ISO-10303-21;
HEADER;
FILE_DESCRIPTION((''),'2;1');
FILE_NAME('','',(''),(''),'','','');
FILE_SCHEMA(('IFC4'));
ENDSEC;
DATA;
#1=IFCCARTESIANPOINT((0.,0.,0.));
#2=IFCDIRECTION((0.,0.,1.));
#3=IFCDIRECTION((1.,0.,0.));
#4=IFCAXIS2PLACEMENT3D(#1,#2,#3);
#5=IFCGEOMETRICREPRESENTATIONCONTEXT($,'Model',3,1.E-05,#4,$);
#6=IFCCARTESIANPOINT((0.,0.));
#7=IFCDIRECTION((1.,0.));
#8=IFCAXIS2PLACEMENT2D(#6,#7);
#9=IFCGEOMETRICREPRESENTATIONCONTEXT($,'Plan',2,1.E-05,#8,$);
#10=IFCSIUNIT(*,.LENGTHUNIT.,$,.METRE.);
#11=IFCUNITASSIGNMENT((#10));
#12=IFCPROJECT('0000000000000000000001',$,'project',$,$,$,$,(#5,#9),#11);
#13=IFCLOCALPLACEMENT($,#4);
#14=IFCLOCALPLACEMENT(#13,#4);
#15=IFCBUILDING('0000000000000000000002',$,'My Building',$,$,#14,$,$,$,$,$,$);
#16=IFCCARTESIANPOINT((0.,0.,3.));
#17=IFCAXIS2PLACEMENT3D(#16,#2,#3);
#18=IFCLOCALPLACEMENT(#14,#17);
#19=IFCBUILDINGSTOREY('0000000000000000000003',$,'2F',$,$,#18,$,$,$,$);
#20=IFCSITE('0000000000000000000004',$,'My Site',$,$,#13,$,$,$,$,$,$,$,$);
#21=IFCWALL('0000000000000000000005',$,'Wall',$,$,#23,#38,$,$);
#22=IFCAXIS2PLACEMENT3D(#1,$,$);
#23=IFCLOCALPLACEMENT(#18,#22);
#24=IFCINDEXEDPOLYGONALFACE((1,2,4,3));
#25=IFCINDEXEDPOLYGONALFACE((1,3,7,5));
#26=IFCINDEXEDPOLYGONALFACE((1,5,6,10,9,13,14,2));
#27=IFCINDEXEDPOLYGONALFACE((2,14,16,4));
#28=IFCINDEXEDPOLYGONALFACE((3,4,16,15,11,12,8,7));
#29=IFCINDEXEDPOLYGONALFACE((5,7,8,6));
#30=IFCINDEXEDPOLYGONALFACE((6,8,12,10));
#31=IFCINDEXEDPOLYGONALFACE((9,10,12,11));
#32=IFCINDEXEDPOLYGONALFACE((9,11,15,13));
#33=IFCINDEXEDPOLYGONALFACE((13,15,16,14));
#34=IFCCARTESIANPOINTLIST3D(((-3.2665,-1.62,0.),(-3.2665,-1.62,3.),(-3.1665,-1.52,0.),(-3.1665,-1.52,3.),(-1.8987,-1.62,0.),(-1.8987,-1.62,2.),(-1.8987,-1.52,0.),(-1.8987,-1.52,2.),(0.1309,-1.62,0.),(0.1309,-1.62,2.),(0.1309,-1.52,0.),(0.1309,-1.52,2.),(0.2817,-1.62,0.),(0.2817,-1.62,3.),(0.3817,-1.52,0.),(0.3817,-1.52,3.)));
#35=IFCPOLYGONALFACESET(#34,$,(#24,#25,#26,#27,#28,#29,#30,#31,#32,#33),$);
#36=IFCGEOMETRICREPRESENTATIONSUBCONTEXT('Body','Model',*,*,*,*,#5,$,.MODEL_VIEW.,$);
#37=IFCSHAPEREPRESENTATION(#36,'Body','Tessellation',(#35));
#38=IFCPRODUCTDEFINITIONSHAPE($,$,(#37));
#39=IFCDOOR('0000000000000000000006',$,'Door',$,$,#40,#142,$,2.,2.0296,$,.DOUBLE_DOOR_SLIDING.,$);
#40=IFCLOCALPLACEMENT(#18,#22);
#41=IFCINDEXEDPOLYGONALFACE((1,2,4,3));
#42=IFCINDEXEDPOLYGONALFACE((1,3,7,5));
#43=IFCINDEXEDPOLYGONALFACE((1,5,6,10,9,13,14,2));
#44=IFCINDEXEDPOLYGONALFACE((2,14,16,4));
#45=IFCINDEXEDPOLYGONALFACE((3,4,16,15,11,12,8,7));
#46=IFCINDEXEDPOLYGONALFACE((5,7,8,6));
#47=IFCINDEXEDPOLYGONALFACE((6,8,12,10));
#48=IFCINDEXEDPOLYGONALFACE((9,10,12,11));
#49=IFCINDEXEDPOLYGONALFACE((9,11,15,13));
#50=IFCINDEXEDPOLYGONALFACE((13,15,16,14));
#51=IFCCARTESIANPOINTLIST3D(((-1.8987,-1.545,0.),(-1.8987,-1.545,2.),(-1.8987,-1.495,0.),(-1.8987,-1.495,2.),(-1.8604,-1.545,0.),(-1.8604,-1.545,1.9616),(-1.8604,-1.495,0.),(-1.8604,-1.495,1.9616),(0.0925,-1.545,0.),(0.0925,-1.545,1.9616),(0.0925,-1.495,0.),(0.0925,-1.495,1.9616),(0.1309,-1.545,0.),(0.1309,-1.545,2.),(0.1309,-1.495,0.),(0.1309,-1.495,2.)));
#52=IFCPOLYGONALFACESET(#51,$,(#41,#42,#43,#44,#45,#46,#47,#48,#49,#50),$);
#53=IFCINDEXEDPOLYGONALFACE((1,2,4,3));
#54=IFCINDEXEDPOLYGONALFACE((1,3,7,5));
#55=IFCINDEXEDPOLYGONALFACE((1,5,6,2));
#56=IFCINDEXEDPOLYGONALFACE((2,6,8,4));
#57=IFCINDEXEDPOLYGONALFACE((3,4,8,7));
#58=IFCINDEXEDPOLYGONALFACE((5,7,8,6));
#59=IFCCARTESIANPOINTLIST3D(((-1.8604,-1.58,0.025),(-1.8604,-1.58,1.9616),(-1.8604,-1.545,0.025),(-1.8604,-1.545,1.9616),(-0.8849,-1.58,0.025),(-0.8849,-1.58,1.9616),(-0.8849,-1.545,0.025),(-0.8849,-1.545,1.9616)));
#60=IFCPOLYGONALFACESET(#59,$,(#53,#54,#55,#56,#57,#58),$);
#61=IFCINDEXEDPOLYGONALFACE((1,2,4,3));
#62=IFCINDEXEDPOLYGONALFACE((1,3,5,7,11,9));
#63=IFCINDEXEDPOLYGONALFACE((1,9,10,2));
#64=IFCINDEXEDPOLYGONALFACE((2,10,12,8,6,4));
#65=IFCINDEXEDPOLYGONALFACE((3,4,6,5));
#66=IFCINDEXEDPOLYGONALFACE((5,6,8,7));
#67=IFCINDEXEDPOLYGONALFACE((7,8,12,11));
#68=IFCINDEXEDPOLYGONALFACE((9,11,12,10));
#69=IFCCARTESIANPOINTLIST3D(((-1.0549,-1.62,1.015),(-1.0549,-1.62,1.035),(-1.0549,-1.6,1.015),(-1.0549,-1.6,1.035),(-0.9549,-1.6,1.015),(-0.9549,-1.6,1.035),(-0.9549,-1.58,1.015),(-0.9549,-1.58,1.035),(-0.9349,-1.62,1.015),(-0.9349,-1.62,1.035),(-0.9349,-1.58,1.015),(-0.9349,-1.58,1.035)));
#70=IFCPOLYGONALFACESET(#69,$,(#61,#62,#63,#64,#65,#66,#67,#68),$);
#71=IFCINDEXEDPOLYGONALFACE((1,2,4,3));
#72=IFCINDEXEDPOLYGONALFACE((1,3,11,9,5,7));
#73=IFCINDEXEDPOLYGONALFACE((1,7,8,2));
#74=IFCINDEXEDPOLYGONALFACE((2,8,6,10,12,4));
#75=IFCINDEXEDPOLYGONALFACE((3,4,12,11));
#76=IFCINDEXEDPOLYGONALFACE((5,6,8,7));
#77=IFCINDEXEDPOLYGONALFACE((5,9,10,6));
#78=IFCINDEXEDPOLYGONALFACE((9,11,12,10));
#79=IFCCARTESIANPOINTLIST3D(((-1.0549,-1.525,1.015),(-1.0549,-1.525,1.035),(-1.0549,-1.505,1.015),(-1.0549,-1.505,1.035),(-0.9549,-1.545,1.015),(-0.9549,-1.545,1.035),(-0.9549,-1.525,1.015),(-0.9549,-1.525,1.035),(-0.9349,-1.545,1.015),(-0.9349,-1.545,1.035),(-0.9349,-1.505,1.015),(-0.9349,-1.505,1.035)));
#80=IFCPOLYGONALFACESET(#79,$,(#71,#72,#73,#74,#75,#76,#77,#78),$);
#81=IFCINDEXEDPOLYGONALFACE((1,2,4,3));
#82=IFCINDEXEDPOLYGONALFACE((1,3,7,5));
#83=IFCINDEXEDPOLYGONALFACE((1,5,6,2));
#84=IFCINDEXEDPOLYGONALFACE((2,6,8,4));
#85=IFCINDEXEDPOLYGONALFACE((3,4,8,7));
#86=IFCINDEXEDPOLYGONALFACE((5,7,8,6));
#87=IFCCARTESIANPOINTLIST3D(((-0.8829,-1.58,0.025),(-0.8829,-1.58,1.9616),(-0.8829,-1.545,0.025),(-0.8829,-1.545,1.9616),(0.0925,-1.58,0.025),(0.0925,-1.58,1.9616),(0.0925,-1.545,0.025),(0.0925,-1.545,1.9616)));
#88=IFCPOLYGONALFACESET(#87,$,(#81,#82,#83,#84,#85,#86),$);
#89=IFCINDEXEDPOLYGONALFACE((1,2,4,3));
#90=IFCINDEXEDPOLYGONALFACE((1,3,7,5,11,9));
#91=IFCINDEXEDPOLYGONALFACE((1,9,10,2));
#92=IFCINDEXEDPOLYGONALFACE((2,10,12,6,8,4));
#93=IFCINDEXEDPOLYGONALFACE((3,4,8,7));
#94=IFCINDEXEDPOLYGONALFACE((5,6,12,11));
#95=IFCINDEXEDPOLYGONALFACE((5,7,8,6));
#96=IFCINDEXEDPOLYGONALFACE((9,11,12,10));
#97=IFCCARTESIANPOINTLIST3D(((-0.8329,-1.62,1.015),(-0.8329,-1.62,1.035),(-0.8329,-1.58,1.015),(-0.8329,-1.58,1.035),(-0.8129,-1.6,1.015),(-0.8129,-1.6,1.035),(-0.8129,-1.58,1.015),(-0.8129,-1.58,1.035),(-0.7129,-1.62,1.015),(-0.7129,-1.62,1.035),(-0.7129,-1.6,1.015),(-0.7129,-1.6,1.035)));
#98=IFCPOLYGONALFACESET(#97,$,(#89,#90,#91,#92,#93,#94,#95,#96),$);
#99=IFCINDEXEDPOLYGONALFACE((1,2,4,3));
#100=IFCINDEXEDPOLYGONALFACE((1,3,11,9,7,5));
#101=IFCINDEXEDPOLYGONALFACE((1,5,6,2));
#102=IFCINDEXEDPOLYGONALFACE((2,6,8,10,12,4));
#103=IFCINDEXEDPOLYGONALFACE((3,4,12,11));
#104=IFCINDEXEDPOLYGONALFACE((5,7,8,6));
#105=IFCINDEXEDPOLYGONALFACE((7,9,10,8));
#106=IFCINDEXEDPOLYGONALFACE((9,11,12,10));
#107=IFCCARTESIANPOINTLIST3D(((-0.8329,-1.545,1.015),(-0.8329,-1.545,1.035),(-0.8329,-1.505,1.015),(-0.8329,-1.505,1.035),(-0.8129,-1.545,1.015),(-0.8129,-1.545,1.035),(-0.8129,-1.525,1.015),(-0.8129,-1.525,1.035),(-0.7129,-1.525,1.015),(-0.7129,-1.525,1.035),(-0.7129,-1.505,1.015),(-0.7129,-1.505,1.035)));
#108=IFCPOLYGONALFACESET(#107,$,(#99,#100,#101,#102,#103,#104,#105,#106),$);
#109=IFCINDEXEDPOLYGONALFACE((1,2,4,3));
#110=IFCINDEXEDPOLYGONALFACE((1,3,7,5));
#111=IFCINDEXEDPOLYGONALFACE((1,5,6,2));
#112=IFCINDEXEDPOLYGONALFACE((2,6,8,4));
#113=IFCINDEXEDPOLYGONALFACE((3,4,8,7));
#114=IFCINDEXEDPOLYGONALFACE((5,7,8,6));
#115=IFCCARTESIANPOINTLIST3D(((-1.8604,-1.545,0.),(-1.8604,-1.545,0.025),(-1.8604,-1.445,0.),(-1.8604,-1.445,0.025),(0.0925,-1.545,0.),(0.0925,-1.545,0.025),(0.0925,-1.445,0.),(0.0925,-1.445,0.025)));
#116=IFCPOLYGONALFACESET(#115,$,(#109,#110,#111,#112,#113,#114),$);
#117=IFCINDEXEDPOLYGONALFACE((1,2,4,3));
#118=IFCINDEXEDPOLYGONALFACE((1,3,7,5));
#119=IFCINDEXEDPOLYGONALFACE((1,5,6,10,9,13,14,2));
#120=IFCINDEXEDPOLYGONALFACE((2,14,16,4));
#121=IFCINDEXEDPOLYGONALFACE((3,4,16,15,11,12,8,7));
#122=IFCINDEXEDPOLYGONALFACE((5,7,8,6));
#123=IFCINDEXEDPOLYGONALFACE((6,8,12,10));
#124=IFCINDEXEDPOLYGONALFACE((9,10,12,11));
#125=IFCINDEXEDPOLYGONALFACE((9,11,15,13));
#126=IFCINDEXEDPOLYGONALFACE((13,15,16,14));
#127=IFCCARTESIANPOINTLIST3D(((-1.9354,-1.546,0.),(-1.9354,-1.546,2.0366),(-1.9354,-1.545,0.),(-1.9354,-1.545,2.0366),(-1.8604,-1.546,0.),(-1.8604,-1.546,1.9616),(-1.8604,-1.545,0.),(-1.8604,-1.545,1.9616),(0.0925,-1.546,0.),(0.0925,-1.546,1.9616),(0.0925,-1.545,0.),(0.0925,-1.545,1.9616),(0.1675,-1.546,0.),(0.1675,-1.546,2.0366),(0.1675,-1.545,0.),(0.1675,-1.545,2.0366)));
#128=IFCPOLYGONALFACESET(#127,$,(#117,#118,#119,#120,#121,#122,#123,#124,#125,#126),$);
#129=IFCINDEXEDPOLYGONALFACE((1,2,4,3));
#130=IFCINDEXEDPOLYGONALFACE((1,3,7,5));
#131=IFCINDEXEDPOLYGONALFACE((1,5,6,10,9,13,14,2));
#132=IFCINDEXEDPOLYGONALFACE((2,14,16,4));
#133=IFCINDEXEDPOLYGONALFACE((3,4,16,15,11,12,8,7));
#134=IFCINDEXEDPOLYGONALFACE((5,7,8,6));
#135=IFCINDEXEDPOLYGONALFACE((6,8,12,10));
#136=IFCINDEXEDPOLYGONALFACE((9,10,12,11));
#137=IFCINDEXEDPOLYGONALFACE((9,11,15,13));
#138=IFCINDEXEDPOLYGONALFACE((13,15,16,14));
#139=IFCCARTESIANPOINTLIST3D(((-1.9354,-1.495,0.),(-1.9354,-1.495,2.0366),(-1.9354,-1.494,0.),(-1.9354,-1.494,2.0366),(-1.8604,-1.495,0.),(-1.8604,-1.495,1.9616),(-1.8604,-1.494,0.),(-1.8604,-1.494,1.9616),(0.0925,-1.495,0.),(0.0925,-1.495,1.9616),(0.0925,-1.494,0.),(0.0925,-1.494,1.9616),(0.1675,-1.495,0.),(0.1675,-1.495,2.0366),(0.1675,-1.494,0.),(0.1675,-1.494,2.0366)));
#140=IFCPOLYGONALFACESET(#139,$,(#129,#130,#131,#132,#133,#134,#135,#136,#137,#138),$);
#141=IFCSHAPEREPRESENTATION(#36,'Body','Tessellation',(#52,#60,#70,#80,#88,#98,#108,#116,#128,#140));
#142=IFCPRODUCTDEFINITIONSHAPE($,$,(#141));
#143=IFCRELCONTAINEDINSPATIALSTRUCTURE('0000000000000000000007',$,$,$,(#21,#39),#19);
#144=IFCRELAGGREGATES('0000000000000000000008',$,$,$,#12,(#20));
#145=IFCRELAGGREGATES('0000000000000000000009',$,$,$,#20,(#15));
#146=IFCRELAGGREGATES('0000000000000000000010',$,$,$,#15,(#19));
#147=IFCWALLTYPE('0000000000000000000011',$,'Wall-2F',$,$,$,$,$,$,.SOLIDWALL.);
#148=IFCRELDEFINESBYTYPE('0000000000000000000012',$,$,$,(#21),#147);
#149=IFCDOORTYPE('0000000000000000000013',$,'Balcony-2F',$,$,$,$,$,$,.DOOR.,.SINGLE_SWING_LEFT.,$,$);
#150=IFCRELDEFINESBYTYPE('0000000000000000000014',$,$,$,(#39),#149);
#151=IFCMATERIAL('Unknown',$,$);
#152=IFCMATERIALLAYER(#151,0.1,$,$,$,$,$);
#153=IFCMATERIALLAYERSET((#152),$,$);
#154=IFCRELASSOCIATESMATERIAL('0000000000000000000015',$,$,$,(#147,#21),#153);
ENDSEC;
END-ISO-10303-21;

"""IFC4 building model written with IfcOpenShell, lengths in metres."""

from ifc_helpers import new_model, entity, si_unit, frame, origin_with_axes, origin_2d_with_axis, place, context, subcontext, project, spatial, line, indexed_curve, outline, extrude, shape, source, transform, mapped, material, layer, layer_set, layer_usage, type_object, type_shapes, element, fill, save


model = new_model("IFC4")

# Units and contexts
model_context = context("Model", 3, precision=1e-05, world=origin_with_axes())
plan_context = context("Plan", 2, precision=1e-05, world=origin_2d_with_axis())
body_context_1 = subcontext(model_context, "Body", "Model", "MODEL_VIEW")
body_context_2 = subcontext(plan_context, "Body", "Plan", "PLAN_VIEW")
ifc_project = project(units=[si_unit("LENGTHUNIT", "METRE")], contexts=[model_context, plan_context])

# Site, building, storey
site_placement = place(None, origin_with_axes())
site = spatial("IfcSite", under=ifc_project, at=site_placement, Name="My Site")
building_placement = place(site_placement, origin_with_axes())
building = spatial("IfcBuilding", under=site, at=building_placement, Name="My Building")
storey_placement = place(building_placement, frame((0.0, 0.0, 3.0), z_axis=(0.0, 0.0, 1.0), x_axis=(1.0, 0.0, 0.0)))
storey = spatial("IfcBuildingStorey", under=building, at=storey_placement, Name="2F")

# Shared definitions
ifc_material = material(Name="Unknown")

# Wall, opening, door
ifc_layer_1 = layer(ifc_material, 0.1)
ifc_layer_set_1 = layer_set([ifc_layer_1])
ifc_layer_usage_1 = layer_usage(ifc_layer_set_1, "AXIS2", "POSITIVE", 0.0)
wall_type_1 = type_object("IfcWallType", Name="Wall-2F", PredefinedType="SOLIDWALL", material=ifc_layer_set_1)
wall_1_placement = place(storey_placement, frame((-3.2665, -1.62, 0.0), z_axis=(0.0, 0.0, 1.0), x_axis=(1.0, 0.0, 0.0)))
wall_1 = element("IfcWall", 1, at=wall_1_placement, inside=storey, type_object=wall_type_1, material=ifc_layer_usage_1, Name="Wall", context=body_context_1, shape_type="SweptSolid", body=[
    extrude(outline(indexed_curve([(0.0, 0.0), (0.1, 0.1), (3.6482, 0.1), (3.5482, 0.0)], segments=[line(1, 2, 3, 4, 1)])), origin_with_axes(), (0.0, 0.0, 1.0), 3.0),
])
shared_shape_1 = source(origin_with_axes(), body_context_1, "Body", "SweptSolid", [
    extrude(outline(indexed_curve([(0.0, 0.0), (2.0296, 0.0), (2.0296, 2.0), (0.0, 2.0)], segments=[line(1, 2, 3, 4, 1)])), frame((0.0, -0.6, 0.0), z_axis=(0.0, -1.0, 0.0), x_axis=(1.0, 0.0, 0.0)), (0.0, 0.0, -1.0), 1.2),
])
opening_1_placement = place(wall_1_placement, frame((1.3677, 0.075, 0.0), z_axis=(0.0, 0.0, 1.0), x_axis=(1.0, 0.0, 0.0)))
opening_1 = element("IfcOpeningElement", 2, at=opening_1_placement, cuts=wall_1, PredefinedType="OPENING", context=body_context_1, shape_type="MappedRepresentation", body=[
    mapped(shared_shape_1, transform((0.0, 0.0, 0.0), x_axis=(1.0, 0.0, 0.0), y_axis=(0.0, 1.0, 0.0), z_axis=(0.0, 0.0, 1.0), scale=1.0)),
])
door_type_1 = type_object("IfcDoorType", Name="Balcony-2F", OperationType="SINGLE_SWING_LEFT", PredefinedType="DOOR")
shared_shape_2 = source(origin_with_axes(), body_context_1, "Body", "SweptSolid", [
    extrude(outline(indexed_curve([(0.0, 0.0), (0.0, 2.0), (2.0296, 2.0), (2.0296, 0.0), (1.9912, 0.0), (1.9912, 1.9616), (0.0384, 1.9616), (0.0384, 0.0)], segments=[line(1, 2, 3, 4, 5, 6, 7, 8, 1)])), frame((0.0, 0.0, 0.0), z_axis=(0.0, -1.0, 0.0), x_axis=(1.0, 0.0, 0.0)), (0.0, 0.0, -1.0), 0.05),
    extrude(outline(indexed_curve([(0.0, 0.0), (0.9754, 0.0), (0.9754, 0.035), (0.0, 0.035)], segments=[line(1, 2, 3, 4, 1)])), frame((0.0384, -0.035, 0.025), z_axis=(0.0, 0.0, 1.0), x_axis=(1.0, 0.0, 0.0)), (0.0, 0.0, 1.0), 1.9366),
    extrude(outline(indexed_curve([(0.0, 0.0), (0.0, -0.04), (-0.12, -0.04), (-0.12, -0.02), (-0.02, -0.02), (-0.02, 0.0)], segments=[line(1, 2, 3, 4, 5, 6, 1)])), frame((0.9638, -0.035, 1.015), z_axis=(0.0, 0.0, 1.0), x_axis=(1.0, 0.0, 0.0)), (0.0, 0.0, 1.0), 0.02),
    extrude(outline(indexed_curve([(0.0, 0.0), (0.0, 0.04), (-0.12, 0.04), (-0.12, 0.02), (-0.02, 0.02), (-0.02, 0.0)], segments=[line(1, 2, 3, 4, 5, 6, 1)])), frame((0.9638, 0.0, 1.015), z_axis=(0.0, 0.0, 1.0), x_axis=(1.0, 0.0, 0.0)), (0.0, 0.0, 1.0), 0.02),
    extrude(outline(indexed_curve([(0.0, 0.0), (-0.9754, 0.0), (-0.9754, 0.035), (0.0, 0.035)], segments=[line(1, 2, 3, 4, 1)])), frame((1.9912, -0.035, 0.025), z_axis=(0.0, 0.0, 1.0), x_axis=(1.0, 0.0, 0.0)), (0.0, 0.0, 1.0), 1.9366),
    extrude(outline(indexed_curve([(0.0, 0.0), (0.0, -0.04), (0.12, -0.04), (0.12, -0.02), (0.02, -0.02), (0.02, 0.0)], segments=[line(1, 2, 3, 4, 5, 6, 1)])), frame((1.0658, -0.035, 1.015), z_axis=(0.0, 0.0, 1.0), x_axis=(1.0, 0.0, 0.0)), (0.0, 0.0, 1.0), 0.02),
    extrude(outline(indexed_curve([(0.0, 0.0), (0.0, 0.04), (0.12, 0.04), (0.12, 0.02), (0.02, 0.02), (0.02, 0.0)], segments=[line(1, 2, 3, 4, 5, 6, 1)])), frame((1.0658, 0.0, 1.015), z_axis=(0.0, 0.0, 1.0), x_axis=(1.0, 0.0, 0.0)), (0.0, 0.0, 1.0), 0.02),
    extrude(outline(indexed_curve([(0.0, 0.0), (1.9529, 0.0), (1.9529, 0.1), (0.0, 0.1)], segments=[line(1, 2, 3, 4, 1)])), frame((0.0384, 0.0, 0.0), z_axis=(0.0, 0.0, 1.0), x_axis=(1.0, 0.0, 0.0)), (0.0, 0.0, 1.0), 0.025),
    extrude(outline(indexed_curve([(0.0, 0.0), (0.0, 2.0366), (2.1029, 2.0366), (2.1029, 0.0), (2.0279, 0.0), (2.0279, 1.9616), (0.075, 1.9616), (0.075, 0.0)], segments=[line(1, 2, 3, 4, 5, 6, 7, 8, 1)])), frame((-0.0366, -0.001, 0.0), z_axis=(0.0, -1.0, 0.0), x_axis=(1.0, 0.0, 0.0)), (0.0, 0.0, -1.0), 0.001),
    extrude(outline(indexed_curve([(0.0, 0.0), (0.0, 2.0366), (2.1029, 2.0366), (2.1029, 0.0), (2.0279, 0.0), (2.0279, 1.9616), (0.075, 1.9616), (0.075, 0.0)], segments=[line(1, 2, 3, 4, 5, 6, 7, 8, 1)])), frame((-0.0366, 0.05, 0.0), z_axis=(0.0, -1.0, 0.0), x_axis=(1.0, 0.0, 0.0)), (0.0, 0.0, -1.0), 0.001),
])
shared_shape_3 = source(origin_with_axes(), body_context_2, "Body", "Curve2D", [
    entity("IfcIndexedPolyCurve", entity("IfcCartesianPointList2D", [[0.0, 0.0], [0.0384, 0.0], [0.0384, 0.05], [0.0, 0.05]]), [entity("IfcLineIndex", [1, 2, 3, 4, 1])]),
    entity("IfcIndexedPolyCurve", entity("IfcCartesianPointList2D", [[2.0296, 0.0], [1.9912, 0.0], [1.9912, 0.05], [2.0296, 0.05]]), [entity("IfcLineIndex", [1, 2, 3, 4, 1])]),
    entity("IfcIndexedPolyCurve", entity("IfcCartesianPointList2D", [[-0.4498, -0.035], [0.5266, -0.035], [0.5266, 0.0], [-0.4498, 0.0]]), [entity("IfcLineIndex", [1, 2, 3, 4, 1])]),
    entity("IfcIndexedPolyCurve", entity("IfcCartesianPointList2D", [[2.4794, -0.035], [1.503, -0.035], [1.503, 0.0], [2.4794, 0.0]]), [entity("IfcLineIndex", [1, 2, 3, 4, 1])]),
])
type_shapes(door_type_1, [shared_shape_2, shared_shape_3])
door_1_placement = place(opening_1_placement, frame((0.0, 0.0, 0.0), z_axis=(0.0, 0.0, 1.0), x_axis=(1.0, 0.0, 0.0)))
door_1 = element("IfcDoor", 3, at=door_1_placement, inside=storey, type_object=door_type_1, Name="Door", OperationType="DOUBLE_DOOR_SLIDING", OverallHeight=2.0, OverallWidth=2.0296, shapes=[
    shape(body_context_1, "Body", "MappedRepresentation", [mapped(shared_shape_2, transform((0.0, 0.0, 0.0), x_axis=(1.0, 0.0, 0.0), y_axis=(0.0, 1.0, 0.0), z_axis=(0.0, 0.0, 1.0), scale=1.0))]),
    shape(body_context_2, "Body", "MappedRepresentation", [mapped(shared_shape_3, transform((0.0, 0.0, 0.0), x_axis=(1.0, 0.0, 0.0), y_axis=(0.0, 1.0, 0.0), z_axis=(0.0, 0.0, 1.0), scale=1.0))]),
])
fill(opening_1, door_1)

save(model, "model.ifc")
